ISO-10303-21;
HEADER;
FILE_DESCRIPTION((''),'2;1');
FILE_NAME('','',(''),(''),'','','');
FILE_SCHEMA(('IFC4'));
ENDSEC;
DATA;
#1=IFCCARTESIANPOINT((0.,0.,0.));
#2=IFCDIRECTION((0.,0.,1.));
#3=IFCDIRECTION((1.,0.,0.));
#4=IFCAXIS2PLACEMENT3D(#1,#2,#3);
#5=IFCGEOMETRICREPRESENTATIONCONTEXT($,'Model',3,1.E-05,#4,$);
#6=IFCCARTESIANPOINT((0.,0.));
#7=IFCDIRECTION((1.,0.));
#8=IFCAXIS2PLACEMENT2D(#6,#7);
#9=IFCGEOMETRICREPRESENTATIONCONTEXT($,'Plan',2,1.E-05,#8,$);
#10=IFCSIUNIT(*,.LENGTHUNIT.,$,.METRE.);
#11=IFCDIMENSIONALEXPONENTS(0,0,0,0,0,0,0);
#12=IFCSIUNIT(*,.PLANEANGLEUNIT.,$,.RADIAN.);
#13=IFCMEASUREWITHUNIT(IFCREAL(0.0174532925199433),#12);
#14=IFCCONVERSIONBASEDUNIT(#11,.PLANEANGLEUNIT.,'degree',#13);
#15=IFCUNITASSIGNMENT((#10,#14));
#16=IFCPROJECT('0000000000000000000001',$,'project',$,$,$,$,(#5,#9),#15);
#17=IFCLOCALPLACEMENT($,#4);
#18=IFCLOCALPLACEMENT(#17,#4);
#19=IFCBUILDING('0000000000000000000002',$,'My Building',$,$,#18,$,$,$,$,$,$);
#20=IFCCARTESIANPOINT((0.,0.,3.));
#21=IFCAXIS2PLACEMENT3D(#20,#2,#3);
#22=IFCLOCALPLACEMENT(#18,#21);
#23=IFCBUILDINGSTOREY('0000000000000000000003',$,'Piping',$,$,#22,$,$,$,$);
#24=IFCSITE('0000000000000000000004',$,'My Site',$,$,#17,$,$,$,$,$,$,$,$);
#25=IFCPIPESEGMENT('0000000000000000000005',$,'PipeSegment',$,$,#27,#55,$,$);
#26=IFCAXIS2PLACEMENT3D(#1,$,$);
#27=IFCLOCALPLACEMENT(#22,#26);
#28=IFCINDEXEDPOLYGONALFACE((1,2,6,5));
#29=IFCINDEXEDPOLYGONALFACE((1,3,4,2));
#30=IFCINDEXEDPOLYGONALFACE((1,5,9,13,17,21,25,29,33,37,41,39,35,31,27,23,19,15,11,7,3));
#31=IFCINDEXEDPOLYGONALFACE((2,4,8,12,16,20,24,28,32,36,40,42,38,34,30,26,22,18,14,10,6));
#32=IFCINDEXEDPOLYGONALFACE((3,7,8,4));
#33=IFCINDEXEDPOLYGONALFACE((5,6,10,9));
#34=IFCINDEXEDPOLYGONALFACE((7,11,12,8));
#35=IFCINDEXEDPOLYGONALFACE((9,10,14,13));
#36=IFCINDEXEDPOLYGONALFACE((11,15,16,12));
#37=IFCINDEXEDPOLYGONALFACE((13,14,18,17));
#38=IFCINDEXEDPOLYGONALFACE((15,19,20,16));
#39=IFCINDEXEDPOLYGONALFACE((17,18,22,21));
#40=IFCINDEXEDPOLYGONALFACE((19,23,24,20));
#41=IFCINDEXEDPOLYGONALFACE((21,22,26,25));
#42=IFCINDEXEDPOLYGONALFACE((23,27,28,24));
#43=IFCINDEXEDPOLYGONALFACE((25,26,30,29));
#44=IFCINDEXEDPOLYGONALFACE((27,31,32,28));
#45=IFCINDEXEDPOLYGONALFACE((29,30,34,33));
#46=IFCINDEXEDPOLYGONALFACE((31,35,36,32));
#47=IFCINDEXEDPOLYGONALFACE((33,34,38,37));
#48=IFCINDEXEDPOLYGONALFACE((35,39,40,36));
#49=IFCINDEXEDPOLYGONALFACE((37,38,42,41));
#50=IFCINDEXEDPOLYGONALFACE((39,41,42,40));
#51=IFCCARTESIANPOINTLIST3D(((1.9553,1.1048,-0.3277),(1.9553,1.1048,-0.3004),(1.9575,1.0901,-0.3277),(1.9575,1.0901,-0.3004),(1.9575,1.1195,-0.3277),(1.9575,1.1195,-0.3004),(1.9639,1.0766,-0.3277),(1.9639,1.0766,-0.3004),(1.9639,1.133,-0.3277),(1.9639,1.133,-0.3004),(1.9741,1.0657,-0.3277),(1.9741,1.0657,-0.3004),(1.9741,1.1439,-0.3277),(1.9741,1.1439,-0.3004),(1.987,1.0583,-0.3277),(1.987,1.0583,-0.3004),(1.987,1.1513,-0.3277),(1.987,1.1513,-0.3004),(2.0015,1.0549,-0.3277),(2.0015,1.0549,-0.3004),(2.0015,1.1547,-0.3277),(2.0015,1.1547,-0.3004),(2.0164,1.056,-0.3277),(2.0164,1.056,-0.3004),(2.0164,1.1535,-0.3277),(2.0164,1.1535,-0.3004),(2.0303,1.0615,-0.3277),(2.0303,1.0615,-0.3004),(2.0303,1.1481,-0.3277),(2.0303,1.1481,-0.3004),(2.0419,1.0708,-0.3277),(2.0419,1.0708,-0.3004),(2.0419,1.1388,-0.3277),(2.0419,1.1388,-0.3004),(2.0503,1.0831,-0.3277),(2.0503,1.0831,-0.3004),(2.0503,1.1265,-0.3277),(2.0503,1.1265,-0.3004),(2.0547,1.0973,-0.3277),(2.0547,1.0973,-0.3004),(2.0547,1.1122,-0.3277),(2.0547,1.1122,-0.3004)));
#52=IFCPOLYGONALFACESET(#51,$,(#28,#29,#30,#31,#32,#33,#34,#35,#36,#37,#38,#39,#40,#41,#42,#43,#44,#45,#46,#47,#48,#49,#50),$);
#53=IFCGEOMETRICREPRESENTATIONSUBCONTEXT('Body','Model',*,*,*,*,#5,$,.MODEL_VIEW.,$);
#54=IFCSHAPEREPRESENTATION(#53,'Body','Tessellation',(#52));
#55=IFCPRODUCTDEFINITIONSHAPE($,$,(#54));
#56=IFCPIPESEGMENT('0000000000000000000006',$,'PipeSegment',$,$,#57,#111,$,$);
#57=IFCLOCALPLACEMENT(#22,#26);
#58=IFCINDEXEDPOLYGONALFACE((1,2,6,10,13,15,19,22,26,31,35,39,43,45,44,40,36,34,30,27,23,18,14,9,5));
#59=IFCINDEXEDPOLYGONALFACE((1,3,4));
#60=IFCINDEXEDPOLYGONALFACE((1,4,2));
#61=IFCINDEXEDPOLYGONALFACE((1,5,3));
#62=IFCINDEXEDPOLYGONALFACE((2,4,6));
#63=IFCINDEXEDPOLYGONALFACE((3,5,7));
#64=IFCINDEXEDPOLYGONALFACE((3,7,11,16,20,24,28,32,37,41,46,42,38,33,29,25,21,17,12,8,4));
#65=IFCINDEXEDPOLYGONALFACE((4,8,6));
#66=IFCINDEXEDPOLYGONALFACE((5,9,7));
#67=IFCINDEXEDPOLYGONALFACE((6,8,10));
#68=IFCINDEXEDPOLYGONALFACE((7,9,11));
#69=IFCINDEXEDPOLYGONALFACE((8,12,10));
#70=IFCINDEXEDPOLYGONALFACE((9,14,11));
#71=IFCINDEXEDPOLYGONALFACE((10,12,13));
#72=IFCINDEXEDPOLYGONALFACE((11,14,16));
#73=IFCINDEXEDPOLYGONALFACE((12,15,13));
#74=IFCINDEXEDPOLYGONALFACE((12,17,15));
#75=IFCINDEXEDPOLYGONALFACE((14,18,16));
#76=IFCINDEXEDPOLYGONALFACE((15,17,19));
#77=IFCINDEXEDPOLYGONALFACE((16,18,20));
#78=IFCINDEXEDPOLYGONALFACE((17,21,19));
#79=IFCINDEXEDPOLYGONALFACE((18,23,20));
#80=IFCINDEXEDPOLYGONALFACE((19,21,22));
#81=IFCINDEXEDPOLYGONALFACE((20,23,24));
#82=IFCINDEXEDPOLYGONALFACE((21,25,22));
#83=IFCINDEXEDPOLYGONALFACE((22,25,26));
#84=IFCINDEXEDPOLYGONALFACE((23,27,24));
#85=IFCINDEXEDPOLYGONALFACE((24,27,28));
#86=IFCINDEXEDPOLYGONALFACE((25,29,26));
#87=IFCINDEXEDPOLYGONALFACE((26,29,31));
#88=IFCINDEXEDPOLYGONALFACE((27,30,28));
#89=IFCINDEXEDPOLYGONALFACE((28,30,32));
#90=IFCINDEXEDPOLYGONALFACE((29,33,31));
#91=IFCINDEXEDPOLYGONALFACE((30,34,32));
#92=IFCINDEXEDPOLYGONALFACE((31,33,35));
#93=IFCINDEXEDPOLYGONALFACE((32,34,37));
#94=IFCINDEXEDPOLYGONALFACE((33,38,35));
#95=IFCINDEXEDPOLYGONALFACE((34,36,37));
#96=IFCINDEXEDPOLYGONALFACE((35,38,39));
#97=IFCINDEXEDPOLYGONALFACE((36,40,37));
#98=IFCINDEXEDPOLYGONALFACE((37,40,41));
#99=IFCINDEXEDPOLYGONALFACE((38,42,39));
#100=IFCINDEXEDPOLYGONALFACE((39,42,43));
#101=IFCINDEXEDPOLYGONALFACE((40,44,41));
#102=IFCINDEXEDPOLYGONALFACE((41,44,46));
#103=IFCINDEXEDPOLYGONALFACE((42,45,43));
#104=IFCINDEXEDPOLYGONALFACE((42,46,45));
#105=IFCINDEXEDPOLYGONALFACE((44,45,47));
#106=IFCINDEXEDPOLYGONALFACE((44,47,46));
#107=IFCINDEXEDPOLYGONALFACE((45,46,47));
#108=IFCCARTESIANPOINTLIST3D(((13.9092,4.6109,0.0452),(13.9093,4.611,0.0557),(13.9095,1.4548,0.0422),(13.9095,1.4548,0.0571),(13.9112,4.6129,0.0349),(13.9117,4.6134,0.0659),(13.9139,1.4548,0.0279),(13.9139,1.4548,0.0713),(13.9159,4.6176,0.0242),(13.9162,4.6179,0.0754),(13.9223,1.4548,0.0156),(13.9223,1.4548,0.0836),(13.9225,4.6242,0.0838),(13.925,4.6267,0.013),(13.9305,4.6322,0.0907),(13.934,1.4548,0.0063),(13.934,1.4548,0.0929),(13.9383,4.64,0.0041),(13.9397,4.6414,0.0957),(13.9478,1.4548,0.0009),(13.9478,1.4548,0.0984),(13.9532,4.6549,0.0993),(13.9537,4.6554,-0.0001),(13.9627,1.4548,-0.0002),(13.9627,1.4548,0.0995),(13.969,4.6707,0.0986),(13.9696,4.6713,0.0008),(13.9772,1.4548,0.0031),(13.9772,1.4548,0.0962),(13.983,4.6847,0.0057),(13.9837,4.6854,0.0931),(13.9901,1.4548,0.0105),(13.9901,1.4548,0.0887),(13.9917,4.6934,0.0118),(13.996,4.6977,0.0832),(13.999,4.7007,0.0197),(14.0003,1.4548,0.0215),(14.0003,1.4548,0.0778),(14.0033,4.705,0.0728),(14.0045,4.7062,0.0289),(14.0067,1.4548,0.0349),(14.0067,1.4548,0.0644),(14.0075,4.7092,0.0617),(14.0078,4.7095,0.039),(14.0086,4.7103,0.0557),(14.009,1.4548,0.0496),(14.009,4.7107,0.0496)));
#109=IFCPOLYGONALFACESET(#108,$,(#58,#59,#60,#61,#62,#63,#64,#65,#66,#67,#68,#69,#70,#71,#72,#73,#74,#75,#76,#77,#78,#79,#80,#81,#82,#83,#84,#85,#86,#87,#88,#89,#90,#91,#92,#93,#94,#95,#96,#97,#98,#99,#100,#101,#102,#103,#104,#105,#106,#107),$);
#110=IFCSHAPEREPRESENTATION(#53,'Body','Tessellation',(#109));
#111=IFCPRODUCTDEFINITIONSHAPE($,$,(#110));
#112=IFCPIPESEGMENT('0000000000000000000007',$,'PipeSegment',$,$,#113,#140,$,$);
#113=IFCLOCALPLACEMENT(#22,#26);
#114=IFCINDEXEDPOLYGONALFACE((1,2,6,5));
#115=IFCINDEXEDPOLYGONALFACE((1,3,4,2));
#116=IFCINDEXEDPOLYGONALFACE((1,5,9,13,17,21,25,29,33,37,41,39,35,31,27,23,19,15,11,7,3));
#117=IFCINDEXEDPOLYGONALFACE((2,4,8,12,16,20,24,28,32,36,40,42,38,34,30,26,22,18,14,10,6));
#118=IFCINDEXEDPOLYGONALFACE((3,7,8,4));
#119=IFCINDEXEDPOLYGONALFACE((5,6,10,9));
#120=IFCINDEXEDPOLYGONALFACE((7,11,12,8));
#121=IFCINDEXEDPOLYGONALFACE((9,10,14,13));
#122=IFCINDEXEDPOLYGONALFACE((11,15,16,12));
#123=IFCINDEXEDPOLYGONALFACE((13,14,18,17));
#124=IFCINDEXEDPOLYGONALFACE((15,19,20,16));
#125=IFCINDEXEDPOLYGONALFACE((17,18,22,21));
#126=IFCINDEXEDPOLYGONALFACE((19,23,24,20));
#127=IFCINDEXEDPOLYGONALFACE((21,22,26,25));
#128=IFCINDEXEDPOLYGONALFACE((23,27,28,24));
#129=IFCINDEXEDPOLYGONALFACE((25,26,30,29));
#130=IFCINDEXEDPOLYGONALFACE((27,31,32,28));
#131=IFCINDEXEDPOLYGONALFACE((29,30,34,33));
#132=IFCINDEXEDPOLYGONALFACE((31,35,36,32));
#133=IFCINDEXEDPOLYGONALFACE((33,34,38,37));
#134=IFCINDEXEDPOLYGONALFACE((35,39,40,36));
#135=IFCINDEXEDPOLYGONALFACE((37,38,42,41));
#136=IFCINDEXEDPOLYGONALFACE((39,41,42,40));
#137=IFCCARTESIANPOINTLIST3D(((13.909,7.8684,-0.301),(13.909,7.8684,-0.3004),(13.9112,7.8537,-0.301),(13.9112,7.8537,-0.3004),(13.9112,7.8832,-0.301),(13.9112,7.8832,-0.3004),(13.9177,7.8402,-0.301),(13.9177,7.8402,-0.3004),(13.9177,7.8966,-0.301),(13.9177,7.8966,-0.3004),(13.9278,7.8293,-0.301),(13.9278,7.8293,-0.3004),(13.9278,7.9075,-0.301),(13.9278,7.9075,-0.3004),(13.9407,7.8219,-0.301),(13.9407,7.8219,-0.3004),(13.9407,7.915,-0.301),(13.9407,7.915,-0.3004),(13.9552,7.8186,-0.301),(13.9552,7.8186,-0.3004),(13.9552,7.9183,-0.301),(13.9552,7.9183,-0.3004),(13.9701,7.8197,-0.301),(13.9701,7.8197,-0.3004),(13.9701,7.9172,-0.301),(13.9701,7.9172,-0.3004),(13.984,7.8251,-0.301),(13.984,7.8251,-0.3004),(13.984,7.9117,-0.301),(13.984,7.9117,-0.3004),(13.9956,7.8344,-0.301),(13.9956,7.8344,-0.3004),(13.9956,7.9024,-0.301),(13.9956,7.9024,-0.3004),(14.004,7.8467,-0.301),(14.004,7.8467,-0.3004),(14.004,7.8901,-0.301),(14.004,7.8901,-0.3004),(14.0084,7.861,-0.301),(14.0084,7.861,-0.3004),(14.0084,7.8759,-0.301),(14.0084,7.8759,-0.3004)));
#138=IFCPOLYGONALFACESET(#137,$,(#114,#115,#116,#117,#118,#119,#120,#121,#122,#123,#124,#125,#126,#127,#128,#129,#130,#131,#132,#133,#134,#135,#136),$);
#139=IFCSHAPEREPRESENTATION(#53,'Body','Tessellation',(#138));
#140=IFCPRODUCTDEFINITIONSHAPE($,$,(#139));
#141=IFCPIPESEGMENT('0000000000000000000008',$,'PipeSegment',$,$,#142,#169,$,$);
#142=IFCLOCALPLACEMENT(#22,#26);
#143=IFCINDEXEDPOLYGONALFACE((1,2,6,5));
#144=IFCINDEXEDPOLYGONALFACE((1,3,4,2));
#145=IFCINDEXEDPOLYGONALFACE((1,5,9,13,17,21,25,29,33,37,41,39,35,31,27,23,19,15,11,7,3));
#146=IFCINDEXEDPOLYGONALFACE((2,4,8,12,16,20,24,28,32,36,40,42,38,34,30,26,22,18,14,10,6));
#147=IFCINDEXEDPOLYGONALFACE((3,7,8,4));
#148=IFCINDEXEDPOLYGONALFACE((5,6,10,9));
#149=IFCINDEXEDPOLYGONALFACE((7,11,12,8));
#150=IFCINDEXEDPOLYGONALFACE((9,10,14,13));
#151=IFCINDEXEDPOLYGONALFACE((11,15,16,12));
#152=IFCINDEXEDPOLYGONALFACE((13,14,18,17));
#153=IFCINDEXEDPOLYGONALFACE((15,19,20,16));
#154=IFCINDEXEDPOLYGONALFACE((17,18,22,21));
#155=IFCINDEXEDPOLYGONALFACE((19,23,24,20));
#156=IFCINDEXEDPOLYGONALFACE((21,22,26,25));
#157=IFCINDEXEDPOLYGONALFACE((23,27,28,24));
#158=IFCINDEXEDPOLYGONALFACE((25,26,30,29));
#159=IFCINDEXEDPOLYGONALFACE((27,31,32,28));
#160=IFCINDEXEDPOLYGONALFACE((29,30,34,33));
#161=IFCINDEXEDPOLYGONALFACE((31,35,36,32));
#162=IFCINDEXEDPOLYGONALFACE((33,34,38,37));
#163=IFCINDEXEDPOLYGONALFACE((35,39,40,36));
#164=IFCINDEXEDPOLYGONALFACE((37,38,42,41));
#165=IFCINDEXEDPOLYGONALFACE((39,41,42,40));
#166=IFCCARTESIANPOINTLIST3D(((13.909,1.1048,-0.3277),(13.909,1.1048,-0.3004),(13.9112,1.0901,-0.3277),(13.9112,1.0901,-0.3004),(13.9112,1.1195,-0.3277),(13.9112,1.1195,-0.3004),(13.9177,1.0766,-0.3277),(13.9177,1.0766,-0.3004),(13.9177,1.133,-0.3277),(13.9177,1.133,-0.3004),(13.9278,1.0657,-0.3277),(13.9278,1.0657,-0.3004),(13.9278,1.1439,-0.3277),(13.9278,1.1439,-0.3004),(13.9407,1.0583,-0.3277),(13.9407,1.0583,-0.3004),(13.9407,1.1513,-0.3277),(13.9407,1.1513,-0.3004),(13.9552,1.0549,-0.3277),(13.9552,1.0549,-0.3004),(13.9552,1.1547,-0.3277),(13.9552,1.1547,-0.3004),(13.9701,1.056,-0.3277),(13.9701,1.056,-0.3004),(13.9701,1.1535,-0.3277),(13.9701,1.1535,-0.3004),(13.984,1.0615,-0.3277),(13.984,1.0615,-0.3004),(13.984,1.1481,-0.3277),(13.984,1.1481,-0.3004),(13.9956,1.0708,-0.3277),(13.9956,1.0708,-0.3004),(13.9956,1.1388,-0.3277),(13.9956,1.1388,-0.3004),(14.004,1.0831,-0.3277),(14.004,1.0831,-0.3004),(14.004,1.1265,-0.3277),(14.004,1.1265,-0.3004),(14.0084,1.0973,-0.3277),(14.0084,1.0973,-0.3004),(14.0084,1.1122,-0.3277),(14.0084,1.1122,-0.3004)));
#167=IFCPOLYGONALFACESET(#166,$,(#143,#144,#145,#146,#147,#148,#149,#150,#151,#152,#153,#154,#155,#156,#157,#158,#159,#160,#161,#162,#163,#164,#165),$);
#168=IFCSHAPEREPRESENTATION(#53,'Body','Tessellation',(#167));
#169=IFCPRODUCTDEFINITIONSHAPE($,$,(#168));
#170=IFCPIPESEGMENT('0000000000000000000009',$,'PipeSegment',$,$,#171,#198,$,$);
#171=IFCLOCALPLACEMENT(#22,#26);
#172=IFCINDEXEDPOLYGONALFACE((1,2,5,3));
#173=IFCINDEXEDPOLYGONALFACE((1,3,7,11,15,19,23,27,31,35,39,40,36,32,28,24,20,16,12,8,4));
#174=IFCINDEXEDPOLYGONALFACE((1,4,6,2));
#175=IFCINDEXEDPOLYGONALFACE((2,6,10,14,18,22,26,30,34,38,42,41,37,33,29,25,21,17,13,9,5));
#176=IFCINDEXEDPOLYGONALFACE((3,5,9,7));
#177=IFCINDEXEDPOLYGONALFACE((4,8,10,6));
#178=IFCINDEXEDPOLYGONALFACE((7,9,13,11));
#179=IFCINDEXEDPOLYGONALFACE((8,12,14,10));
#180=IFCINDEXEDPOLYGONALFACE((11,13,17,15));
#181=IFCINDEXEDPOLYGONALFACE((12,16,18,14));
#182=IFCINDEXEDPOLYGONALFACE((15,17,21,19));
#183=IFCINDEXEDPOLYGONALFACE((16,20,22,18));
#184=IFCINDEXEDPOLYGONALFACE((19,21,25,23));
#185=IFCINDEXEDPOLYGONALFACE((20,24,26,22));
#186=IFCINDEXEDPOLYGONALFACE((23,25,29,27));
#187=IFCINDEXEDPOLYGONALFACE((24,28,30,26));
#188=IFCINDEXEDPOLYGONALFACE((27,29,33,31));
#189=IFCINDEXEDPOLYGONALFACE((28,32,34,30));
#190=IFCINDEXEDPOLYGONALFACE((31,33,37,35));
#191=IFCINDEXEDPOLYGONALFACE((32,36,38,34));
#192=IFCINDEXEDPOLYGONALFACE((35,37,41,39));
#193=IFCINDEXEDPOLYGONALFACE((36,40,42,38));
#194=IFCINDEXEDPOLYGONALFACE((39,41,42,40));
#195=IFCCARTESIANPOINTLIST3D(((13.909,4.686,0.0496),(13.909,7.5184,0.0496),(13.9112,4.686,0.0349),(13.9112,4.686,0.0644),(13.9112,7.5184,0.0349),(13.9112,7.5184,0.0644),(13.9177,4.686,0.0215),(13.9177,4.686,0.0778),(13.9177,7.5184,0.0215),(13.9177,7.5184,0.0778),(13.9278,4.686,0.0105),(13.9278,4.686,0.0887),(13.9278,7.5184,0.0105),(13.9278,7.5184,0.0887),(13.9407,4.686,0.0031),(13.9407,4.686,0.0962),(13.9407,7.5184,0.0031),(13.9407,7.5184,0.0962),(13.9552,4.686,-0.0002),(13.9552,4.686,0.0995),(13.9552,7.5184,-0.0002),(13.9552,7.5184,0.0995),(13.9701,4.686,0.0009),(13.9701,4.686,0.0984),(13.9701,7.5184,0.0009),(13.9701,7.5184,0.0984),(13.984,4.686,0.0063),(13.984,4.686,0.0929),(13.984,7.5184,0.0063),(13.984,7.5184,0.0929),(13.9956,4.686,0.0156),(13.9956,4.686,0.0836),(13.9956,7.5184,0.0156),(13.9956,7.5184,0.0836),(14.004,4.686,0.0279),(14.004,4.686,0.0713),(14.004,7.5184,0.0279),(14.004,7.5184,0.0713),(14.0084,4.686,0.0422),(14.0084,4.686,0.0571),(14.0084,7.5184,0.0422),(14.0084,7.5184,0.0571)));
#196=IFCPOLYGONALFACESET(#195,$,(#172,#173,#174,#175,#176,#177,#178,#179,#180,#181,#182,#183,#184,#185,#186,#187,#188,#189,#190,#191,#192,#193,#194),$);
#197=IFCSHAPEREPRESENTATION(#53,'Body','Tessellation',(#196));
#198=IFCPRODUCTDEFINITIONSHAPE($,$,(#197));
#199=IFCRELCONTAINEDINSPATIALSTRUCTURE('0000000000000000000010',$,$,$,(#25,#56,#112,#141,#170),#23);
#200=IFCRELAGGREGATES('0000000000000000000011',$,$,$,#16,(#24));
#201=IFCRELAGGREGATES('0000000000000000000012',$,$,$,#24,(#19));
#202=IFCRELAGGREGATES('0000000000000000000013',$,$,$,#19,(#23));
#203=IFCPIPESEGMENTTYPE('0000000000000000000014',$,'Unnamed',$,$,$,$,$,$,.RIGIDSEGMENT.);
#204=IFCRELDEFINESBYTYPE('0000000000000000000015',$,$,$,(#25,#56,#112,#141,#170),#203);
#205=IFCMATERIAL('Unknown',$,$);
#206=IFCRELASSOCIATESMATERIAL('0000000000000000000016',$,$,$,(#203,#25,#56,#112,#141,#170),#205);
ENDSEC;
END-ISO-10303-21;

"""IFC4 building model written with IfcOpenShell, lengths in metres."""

from ifc_helpers import new_model, entity, si_unit, converted_unit, frame, origin_with_axes, origin_2d_with_axis, place, context, subcontext, project, spatial, circle, extrude, clip, halfspace, material, material_profile, profile_set, profile_usage, type_object, element, save


model = new_model("IFC4")

# Units and contexts
model_context = context("Model", 3, precision=1e-05, world=origin_with_axes())
plan_context = context("Plan", 2, precision=1e-05, world=origin_2d_with_axis())
body_context = subcontext(model_context, "Body", "Model", "MODEL_VIEW")
ifc_project = project(units=[si_unit("LENGTHUNIT", "METRE"), converted_unit("PLANEANGLEUNIT", "degree", entity("IfcReal", 0.0174532925199433), si_unit("PLANEANGLEUNIT", "RADIAN"), dimensions=[0, 0, 0, 0, 0, 0, 0])], contexts=[model_context, plan_context])

# Site, building, storey
site_placement = place(None, origin_with_axes())
site = spatial("IfcSite", under=ifc_project, at=site_placement, Name="My Site")
building_placement = place(site_placement, origin_with_axes())
building = spatial("IfcBuilding", under=site, at=building_placement, Name="My Building")
storey_placement = place(building_placement, frame((0.0, 0.0, 3.0), z_axis=(0.0, 0.0, 1.0), x_axis=(1.0, 0.0, 0.0)))
storey = spatial("IfcBuildingStorey", under=building, at=storey_placement, Name="Piping")

# Pipe segments
ifc_material = material(Name="Unknown")
ifc_material_profile = material_profile(ifc_material, circle(Radius=0.05))
ifc_profile_set = profile_set([ifc_material_profile])
pipe_segment_type = type_object("IfcPipeSegmentType", Name="Unnamed", PredefinedType="RIGIDSEGMENT", material=ifc_profile_set)
ifc_profile_usage_1 = profile_usage(ifc_profile_set, cardinal=5)
pipe_segment_1_placement = place(storey_placement, frame((2.0053, 1.1048, -0.3004), z_axis=(0.0, 0.0, -1.0), x_axis=(-1.0, 0.0, 0.0)))
element("IfcPipeSegment", 1, at=pipe_segment_1_placement, inside=storey, type_object=pipe_segment_type, material=ifc_profile_usage_1, Name="PipeSegment", context=body_context, shape_type="SweptSolid", body=[
    extrude(circle(Radius=0.05), origin_with_axes(), (0.0, 0.0, 1.0), 0.0273),
])
ifc_profile_usage_2 = profile_usage(ifc_profile_set, cardinal=5)
pipe_segment_2_placement = place(storey_placement, frame((13.959, 4.7107, 0.0496), z_axis=(0.0, -1.0, 0.000007), x_axis=(1.0, 0.0, 0.0)))
element("IfcPipeSegment", 2, at=pipe_segment_2_placement, inside=storey, type_object=pipe_segment_type, material=ifc_profile_usage_2, Name="PipeSegment", context=body_context, shape_type="Clipping", body=[
    clip(extrude(circle(Radius=0.05), origin_with_axes(), (0.0, 0.0, 1.0), 3.2559), halfspace(frame((0.05, -3.0496, 0.0), z_axis=(-0.707114, 0.000005, -0.7071), x_axis=(0.000007, 1.0, 0.0)), False)),
])
ifc_profile_usage_3 = profile_usage(ifc_profile_set, cardinal=5)
pipe_segment_3_placement = place(storey_placement, frame((13.959, 7.8684, -0.3004), z_axis=(0.0, 0.0, -1.0), x_axis=(-1.0, 0.0, 0.0)))
element("IfcPipeSegment", 3, at=pipe_segment_3_placement, inside=storey, type_object=pipe_segment_type, material=ifc_profile_usage_3, Name="PipeSegment", context=body_context, shape_type="SweptSolid", body=[
    extrude(circle(Radius=0.05), origin_with_axes(), (0.0, 0.0, 1.0), 0.0007),
])
ifc_profile_usage_4 = profile_usage(ifc_profile_set, cardinal=5)
pipe_segment_4_placement = place(storey_placement, frame((13.959, 1.1048, -0.3004), z_axis=(0.0, 0.0, -1.0), x_axis=(-1.0, 0.0, 0.0)))
element("IfcPipeSegment", 4, at=pipe_segment_4_placement, inside=storey, type_object=pipe_segment_type, material=ifc_profile_usage_4, Name="PipeSegment", context=body_context, shape_type="SweptSolid", body=[
    extrude(circle(Radius=0.05), origin_with_axes(), (0.0, 0.0, 1.0), 0.0273),
])
ifc_profile_usage_5 = profile_usage(ifc_profile_set, cardinal=5)
pipe_segment_5_placement = place(storey_placement, frame((13.959, 4.686, 0.0496), z_axis=(0.0, 1.0, 0.0), x_axis=(-1.0, 0.0, 0.0)))
element("IfcPipeSegment", 5, at=pipe_segment_5_placement, inside=storey, type_object=pipe_segment_type, material=ifc_profile_usage_5, Name="PipeSegment", context=body_context, shape_type="SweptSolid", body=[
    extrude(circle(Radius=0.05), origin_with_axes(), (0.0, 0.0, 1.0), 2.8324),
])

save(model, "model.ifc")
